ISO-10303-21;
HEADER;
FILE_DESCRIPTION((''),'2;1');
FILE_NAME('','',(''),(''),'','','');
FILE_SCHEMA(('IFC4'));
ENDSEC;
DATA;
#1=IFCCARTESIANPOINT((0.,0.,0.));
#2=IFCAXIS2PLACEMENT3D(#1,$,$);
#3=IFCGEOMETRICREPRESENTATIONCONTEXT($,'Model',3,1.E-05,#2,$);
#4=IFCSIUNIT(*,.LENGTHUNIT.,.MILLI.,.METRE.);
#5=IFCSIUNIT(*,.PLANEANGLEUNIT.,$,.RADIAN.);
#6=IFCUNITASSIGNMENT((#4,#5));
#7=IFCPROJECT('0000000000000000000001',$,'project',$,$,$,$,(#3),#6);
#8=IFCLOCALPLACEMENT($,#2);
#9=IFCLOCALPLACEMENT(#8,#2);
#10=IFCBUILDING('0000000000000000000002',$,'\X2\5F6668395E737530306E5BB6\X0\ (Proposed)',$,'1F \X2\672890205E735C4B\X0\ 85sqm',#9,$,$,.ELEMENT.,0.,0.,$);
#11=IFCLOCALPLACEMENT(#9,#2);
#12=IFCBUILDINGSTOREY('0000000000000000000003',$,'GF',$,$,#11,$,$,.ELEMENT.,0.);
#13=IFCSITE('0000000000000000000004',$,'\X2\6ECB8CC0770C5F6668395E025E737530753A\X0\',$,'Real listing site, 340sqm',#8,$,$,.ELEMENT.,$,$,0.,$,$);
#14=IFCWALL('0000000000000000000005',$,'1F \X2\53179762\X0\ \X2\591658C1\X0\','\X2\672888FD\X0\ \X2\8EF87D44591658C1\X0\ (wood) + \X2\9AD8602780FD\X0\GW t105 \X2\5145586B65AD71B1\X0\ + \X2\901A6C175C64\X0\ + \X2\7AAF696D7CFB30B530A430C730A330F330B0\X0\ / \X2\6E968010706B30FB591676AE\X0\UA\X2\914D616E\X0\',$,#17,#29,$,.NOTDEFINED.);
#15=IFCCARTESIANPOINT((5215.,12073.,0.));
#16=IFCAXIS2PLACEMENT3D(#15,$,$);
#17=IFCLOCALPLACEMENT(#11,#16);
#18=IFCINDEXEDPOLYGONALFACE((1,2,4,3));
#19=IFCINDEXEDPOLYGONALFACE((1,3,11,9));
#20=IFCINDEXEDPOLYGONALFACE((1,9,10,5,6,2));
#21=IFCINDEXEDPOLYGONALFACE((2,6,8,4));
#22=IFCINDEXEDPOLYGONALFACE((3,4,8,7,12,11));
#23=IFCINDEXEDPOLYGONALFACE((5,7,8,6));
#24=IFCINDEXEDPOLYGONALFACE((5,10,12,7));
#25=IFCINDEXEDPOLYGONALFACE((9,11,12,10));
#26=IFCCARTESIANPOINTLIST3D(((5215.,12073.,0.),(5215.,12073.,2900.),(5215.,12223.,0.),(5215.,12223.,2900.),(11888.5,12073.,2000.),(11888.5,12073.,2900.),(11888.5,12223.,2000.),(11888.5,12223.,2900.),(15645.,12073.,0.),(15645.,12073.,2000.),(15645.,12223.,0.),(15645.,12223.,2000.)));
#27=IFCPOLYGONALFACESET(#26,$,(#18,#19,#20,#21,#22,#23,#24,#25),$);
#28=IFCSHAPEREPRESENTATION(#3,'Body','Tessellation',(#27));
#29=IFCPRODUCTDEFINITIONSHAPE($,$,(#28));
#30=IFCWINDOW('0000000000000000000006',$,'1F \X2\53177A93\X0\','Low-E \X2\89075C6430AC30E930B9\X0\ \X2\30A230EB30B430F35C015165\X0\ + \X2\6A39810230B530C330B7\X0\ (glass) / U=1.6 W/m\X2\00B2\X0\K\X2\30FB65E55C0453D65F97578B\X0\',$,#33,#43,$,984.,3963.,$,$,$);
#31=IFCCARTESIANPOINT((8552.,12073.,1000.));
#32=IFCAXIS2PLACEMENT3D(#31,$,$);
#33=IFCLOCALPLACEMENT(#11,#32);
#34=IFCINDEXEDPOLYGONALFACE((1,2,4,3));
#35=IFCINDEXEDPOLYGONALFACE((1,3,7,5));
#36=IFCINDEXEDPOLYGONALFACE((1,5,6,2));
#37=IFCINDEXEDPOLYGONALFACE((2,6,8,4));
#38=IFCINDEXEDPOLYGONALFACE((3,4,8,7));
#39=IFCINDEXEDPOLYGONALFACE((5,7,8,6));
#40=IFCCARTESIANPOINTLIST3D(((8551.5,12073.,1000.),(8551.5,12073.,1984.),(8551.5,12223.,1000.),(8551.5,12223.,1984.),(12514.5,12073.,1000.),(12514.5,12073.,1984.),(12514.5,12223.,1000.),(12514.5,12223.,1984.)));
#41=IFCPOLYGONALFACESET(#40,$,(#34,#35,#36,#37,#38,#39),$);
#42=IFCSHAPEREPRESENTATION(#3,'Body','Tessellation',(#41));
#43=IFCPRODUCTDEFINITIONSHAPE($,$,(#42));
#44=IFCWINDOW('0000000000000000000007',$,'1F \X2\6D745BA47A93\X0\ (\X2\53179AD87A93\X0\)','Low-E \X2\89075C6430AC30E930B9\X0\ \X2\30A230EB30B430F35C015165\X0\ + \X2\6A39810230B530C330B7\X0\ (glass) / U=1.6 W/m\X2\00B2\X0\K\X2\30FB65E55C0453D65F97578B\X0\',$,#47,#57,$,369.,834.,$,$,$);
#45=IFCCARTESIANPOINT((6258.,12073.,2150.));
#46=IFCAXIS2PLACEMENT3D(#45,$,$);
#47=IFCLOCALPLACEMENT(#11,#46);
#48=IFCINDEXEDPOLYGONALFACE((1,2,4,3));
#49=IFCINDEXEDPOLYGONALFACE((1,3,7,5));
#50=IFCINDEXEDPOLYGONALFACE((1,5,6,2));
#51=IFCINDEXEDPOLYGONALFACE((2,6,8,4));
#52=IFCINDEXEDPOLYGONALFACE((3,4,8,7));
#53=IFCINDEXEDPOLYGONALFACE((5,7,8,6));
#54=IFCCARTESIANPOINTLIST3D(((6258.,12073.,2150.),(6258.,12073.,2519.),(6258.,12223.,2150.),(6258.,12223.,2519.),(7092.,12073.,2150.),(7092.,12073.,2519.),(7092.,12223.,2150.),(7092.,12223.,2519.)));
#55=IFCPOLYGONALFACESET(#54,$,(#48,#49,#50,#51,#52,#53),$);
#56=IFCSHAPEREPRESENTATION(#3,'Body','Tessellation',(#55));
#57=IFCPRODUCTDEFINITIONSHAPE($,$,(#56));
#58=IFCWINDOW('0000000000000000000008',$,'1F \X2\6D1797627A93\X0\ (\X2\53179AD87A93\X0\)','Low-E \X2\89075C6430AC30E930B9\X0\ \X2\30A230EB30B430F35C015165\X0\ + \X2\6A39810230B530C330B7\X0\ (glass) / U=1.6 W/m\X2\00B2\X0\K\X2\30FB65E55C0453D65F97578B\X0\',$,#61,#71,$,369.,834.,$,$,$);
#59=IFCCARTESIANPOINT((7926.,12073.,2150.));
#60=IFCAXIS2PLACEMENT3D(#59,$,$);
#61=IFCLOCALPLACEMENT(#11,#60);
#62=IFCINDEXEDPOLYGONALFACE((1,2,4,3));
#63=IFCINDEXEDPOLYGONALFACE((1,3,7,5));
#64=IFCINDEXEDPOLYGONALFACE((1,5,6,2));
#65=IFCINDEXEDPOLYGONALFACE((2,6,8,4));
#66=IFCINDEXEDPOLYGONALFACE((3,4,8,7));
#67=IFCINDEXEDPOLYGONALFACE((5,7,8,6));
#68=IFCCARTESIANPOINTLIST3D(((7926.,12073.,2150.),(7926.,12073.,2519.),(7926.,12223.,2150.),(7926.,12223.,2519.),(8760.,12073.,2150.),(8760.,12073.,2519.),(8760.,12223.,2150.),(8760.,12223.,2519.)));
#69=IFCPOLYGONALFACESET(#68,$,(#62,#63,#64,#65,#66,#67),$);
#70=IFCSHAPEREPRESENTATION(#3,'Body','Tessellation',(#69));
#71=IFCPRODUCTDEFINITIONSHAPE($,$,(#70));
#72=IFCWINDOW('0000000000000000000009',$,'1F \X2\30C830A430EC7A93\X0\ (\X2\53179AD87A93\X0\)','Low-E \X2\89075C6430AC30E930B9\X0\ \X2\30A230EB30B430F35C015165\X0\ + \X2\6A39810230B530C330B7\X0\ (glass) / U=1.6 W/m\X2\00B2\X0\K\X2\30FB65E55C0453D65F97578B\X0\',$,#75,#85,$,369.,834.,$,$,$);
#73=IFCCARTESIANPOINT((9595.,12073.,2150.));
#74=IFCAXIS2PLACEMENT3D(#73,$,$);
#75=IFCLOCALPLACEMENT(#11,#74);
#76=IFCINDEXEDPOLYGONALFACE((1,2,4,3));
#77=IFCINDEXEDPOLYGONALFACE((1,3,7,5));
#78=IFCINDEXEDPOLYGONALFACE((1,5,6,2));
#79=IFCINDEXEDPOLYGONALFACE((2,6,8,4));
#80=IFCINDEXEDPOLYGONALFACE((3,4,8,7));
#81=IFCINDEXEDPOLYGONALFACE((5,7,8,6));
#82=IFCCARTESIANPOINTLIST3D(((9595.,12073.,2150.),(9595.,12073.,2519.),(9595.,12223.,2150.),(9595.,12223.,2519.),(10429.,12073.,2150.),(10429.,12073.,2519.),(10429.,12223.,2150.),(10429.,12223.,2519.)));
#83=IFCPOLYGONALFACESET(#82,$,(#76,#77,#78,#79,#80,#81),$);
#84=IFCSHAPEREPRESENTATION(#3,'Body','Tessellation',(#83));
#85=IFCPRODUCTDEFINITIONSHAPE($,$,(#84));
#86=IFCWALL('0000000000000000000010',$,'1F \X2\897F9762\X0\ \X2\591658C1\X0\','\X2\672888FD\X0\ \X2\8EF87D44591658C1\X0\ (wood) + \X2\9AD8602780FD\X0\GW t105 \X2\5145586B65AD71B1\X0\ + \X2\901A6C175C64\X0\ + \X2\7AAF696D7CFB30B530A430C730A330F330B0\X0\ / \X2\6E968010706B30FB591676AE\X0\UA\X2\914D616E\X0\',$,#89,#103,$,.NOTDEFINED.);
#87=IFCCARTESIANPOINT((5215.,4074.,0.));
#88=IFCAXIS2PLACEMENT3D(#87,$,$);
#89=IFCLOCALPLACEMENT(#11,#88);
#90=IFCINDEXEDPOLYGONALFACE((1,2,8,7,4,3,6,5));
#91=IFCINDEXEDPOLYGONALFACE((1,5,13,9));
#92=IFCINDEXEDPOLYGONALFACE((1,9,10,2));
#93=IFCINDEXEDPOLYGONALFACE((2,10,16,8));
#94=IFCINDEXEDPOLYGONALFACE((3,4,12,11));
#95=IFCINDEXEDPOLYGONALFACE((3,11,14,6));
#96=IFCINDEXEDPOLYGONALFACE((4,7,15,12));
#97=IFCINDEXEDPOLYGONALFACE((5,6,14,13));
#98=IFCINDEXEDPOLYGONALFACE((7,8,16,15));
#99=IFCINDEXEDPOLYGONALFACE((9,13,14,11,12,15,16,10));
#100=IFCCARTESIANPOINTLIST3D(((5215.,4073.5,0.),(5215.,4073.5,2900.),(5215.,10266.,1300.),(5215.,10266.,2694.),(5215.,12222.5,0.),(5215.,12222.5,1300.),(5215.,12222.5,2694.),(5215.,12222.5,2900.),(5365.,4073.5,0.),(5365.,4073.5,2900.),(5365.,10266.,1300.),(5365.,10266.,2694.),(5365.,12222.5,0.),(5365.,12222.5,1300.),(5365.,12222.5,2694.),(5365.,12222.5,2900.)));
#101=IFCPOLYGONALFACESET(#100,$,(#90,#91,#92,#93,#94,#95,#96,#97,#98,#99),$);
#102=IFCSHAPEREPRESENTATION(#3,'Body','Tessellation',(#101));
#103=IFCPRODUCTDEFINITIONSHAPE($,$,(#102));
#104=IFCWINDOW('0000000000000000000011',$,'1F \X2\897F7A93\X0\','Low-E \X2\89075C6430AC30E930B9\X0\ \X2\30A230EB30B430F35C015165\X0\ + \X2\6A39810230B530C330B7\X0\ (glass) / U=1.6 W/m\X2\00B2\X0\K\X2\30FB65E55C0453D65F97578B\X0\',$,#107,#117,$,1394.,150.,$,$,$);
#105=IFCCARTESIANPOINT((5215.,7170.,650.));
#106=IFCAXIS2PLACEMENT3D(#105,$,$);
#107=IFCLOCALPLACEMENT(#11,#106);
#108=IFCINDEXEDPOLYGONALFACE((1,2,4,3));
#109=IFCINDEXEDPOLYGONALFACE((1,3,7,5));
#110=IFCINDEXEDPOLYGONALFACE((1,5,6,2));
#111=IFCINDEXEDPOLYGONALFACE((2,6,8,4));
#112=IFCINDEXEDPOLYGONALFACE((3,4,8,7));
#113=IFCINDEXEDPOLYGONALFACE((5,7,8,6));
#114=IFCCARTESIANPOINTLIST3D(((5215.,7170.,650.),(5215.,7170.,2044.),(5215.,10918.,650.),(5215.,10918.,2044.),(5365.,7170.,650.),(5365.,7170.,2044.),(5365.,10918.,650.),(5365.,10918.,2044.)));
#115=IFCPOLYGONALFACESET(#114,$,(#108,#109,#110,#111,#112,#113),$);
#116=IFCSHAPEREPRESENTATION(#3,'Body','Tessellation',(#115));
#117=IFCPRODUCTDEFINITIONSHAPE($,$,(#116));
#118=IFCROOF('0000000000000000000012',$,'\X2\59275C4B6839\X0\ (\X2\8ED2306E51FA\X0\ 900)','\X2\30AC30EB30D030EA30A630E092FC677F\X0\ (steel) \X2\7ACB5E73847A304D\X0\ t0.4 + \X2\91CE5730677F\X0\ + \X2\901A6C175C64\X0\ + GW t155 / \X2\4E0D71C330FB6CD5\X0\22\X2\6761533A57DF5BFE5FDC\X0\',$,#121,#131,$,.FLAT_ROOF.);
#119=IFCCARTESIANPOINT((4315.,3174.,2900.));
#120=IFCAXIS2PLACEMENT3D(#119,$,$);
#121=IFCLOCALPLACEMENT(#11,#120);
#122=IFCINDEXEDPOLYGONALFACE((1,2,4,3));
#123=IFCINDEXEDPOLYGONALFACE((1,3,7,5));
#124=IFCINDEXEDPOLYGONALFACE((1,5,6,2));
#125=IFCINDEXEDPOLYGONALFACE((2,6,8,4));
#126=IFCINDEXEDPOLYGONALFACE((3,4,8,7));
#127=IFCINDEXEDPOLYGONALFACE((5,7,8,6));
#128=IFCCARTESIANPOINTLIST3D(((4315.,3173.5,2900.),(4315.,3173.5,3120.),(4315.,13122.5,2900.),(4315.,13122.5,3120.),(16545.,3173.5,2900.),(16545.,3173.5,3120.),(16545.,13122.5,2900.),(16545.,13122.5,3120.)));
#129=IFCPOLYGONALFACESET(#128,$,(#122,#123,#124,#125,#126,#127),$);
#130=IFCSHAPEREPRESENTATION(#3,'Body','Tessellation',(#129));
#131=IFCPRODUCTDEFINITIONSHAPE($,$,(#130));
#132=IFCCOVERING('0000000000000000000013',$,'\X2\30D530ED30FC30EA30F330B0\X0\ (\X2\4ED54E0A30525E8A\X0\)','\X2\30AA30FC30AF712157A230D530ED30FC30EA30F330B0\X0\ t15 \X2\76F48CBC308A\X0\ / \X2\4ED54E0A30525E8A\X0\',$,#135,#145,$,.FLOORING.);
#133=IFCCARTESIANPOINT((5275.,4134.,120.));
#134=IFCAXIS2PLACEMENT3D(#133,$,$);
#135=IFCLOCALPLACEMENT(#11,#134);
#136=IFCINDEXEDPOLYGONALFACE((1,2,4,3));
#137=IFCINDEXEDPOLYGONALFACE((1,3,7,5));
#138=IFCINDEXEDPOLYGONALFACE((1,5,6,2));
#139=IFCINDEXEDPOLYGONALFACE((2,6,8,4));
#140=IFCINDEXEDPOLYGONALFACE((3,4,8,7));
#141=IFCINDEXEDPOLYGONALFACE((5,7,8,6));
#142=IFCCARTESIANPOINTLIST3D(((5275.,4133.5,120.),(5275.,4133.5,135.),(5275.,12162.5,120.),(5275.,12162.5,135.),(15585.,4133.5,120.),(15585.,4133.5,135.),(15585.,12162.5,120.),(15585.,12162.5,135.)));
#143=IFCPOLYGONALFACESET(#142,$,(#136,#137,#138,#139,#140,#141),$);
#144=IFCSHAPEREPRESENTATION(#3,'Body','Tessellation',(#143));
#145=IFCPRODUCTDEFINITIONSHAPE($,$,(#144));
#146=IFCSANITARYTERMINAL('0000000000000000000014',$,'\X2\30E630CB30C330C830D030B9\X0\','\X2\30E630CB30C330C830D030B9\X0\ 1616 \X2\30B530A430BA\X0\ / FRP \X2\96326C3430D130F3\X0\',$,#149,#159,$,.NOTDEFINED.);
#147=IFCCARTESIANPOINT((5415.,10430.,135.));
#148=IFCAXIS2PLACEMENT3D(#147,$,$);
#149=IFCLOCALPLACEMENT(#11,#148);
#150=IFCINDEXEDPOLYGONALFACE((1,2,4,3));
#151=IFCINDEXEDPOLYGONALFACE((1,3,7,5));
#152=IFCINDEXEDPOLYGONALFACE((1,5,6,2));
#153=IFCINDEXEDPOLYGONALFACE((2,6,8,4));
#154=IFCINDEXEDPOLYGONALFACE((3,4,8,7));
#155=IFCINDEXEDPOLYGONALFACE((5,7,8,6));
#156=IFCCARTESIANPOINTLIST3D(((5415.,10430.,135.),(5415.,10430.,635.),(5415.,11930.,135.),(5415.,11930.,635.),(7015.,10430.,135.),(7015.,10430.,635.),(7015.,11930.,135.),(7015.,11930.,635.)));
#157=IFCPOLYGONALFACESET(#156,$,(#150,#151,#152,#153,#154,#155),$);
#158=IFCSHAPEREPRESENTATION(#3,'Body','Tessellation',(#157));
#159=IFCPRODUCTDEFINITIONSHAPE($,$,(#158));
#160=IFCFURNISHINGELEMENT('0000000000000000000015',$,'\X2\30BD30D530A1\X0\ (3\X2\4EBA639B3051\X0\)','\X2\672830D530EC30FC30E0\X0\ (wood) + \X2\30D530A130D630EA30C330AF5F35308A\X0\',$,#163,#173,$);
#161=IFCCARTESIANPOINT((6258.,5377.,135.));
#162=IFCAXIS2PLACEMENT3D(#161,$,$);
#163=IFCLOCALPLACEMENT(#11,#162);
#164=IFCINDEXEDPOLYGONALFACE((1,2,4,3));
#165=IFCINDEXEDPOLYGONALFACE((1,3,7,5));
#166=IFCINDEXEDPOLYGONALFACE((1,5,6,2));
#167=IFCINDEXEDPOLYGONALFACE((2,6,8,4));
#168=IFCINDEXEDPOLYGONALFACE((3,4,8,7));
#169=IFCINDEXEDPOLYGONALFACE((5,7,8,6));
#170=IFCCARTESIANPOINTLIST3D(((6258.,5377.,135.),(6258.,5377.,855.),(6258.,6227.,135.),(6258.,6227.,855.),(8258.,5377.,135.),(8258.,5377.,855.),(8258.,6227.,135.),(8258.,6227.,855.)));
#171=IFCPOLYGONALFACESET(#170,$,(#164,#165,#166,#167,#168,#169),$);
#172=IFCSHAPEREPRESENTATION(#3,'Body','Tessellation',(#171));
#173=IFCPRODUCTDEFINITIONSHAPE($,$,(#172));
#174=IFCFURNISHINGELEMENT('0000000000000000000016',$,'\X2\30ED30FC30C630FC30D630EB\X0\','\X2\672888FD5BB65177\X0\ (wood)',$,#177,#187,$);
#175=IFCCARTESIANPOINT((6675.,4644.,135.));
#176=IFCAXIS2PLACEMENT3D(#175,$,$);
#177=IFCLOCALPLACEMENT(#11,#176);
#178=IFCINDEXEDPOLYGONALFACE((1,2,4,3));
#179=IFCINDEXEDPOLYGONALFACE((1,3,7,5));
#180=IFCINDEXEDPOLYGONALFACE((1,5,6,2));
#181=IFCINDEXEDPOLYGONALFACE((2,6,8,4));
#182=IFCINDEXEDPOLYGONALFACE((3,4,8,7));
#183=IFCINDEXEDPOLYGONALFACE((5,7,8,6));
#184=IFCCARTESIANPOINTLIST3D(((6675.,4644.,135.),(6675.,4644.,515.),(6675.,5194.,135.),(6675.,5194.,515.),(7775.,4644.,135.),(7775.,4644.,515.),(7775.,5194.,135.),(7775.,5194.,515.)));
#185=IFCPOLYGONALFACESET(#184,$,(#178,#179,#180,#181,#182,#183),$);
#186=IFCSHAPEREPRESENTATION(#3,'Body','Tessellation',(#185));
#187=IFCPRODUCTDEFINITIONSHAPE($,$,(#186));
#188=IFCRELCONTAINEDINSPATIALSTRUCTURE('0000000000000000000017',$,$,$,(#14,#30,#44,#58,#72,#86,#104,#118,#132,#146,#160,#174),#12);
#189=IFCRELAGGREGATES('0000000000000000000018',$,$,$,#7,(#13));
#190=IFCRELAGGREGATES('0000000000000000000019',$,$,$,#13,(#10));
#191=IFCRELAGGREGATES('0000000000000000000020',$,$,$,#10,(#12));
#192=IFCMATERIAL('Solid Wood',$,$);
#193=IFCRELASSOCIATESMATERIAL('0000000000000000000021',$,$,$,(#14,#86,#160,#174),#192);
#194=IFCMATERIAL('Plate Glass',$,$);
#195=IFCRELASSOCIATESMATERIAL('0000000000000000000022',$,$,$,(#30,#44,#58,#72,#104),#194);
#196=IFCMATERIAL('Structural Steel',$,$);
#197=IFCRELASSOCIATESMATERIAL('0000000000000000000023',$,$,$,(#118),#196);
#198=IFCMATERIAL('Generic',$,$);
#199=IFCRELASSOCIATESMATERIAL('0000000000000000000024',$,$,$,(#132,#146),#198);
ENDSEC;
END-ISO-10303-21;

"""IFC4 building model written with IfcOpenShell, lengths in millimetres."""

from ifc_helpers import new_model, si_unit, frame, frame_2d, origin, place, context, project, spatial, rectangle, extrude, material, element, fill, save


model = new_model("IFC4")

# Units and contexts
model_context = context("Model", 3, precision=1e-05, world=origin())
ifc_project = project(units=[si_unit("LENGTHUNIT", "METRE", prefix="MILLI"), si_unit("PLANEANGLEUNIT", "RADIAN")], contexts=[model_context])

# Site, building, storey
site_placement = place(None, origin())
site = spatial("IfcSite", under=ifc_project, at=site_placement, Name="滋賀県彦根市平田町", ObjectType="Real listing site, 340sqm", CompositionType="ELEMENT", RefElevation=0.0)
building_placement = place(site_placement, origin())
building = spatial("IfcBuilding", under=site, at=building_placement, Name="彦根平田の家 (Proposed)", ObjectType="1F 木造平屋 85sqm", CompositionType="ELEMENT", ElevationOfRefHeight=0.0, ElevationOfTerrain=0.0)
storey_placement = place(building_placement, origin())
storey = spatial("IfcBuildingStorey", under=building, at=storey_placement, Name="GF", CompositionType="ELEMENT", Elevation=0.0)

# Shared definitions
ifc_material_1 = material(Name="Solid Wood")

# Shared definitions
ifc_material_2 = material(Name="Plate Glass")

# Wall, openings, windows
wall_1_placement = place(storey_placement, frame((5215.0, 12073.0, 0.0)))
wall_1 = element("IfcWall", 1, at=wall_1_placement, inside=storey, material=ifc_material_1, Name="1F 北面 外壁", Description="木製 軸組外壁 (wood) + 高性能GW t105 充填断熱 + 通気層 + 窯業系サイディング / 準耐火・外皮UA配慮", PredefinedType="NOTDEFINED", context=model_context, shape_type="SweptSolid", body=[
    extrude(rectangle(XDim=10430.0, YDim=150.0, at=frame_2d((5215.0, 75.0))), frame((5215.0, 12073.0, 0.0)), (0.0, 0.0, 1.0), 2900.0),
])
opening_1_placement = place(storey_placement, frame((8552.0, 12073.0, 1000.0)))
opening_1 = element("IfcOpeningElement", 2, at=opening_1_placement, cuts=wall_1, PredefinedType="NOTDEFINED", context=model_context, shape_type="SweptSolid", body=[
    extrude(rectangle(XDim=3963.0, YDim=150.0, at=frame_2d((1981.0, 75.0))), frame((8552.0, 12073.0, 1000.0)), (0.0, 0.0, 1.0), 984.0),
])
opening_2_placement = place(storey_placement, frame((6258.0, 12073.0, 2150.0)))
opening_2 = element("IfcOpeningElement", 3, at=opening_2_placement, cuts=wall_1, PredefinedType="NOTDEFINED", context=model_context, shape_type="SweptSolid", body=[
    extrude(rectangle(XDim=834.0, YDim=150.0, at=frame_2d((417.0, 75.0))), frame((6258.0, 12073.0, 2150.0)), (0.0, 0.0, 1.0), 369.0),
])
opening_3_placement = place(storey_placement, frame((7926.0, 12073.0, 2150.0)))
opening_3 = element("IfcOpeningElement", 4, at=opening_3_placement, cuts=wall_1, PredefinedType="NOTDEFINED", context=model_context, shape_type="SweptSolid", body=[
    extrude(rectangle(XDim=834.0, YDim=150.0, at=frame_2d((417.0, 75.0))), frame((7926.0, 12073.0, 2150.0)), (0.0, 0.0, 1.0), 369.0),
])
opening_4_placement = place(storey_placement, frame((9595.0, 12073.0, 2150.0)))
opening_4 = element("IfcOpeningElement", 5, at=opening_4_placement, cuts=wall_1, PredefinedType="NOTDEFINED", context=model_context, shape_type="SweptSolid", body=[
    extrude(rectangle(XDim=834.0, YDim=150.0, at=frame_2d((417.0, 75.0))), frame((9595.0, 12073.0, 2150.0)), (0.0, 0.0, 1.0), 369.0),
])
window_1_placement = place(storey_placement, frame((8552.0, 12073.0, 1000.0)))
window_1 = element("IfcWindow", 6, at=window_1_placement, inside=storey, material=ifc_material_2, Name="1F 北窓", Description="Low-E 複層ガラス アルゴン封入 + 樹脂サッシ (glass) / U=1.6 W/m²K・日射取得型", OverallHeight=984.0, OverallWidth=3963.0, context=model_context, shape_type="SweptSolid", body=[
    extrude(rectangle(XDim=3963.0, YDim=150.0, at=frame_2d((1981.0, 75.0))), frame((8552.0, 12073.0, 1000.0)), (0.0, 0.0, 1.0), 984.0),
])
fill(opening_1, window_1)
window_2_placement = place(storey_placement, frame((6258.0, 12073.0, 2150.0)))
window_2 = element("IfcWindow", 7, at=window_2_placement, inside=storey, material=ifc_material_2, Name="1F 浴室窓 (北高窓)", Description="Low-E 複層ガラス アルゴン封入 + 樹脂サッシ (glass) / U=1.6 W/m²K・日射取得型", OverallHeight=369.0, OverallWidth=834.0, context=model_context, shape_type="SweptSolid", body=[
    extrude(rectangle(XDim=834.0, YDim=150.0, at=frame_2d((417.0, 75.0))), frame((6258.0, 12073.0, 2150.0)), (0.0, 0.0, 1.0), 369.0),
])
fill(opening_2, window_2)
window_3_placement = place(storey_placement, frame((7926.0, 12073.0, 2150.0)))
window_3 = element("IfcWindow", 8, at=window_3_placement, inside=storey, material=ifc_material_2, Name="1F 洗面窓 (北高窓)", Description="Low-E 複層ガラス アルゴン封入 + 樹脂サッシ (glass) / U=1.6 W/m²K・日射取得型", OverallHeight=369.0, OverallWidth=834.0, context=model_context, shape_type="SweptSolid", body=[
    extrude(rectangle(XDim=834.0, YDim=150.0, at=frame_2d((417.0, 75.0))), frame((7926.0, 12073.0, 2150.0)), (0.0, 0.0, 1.0), 369.0),
])
fill(opening_3, window_3)
window_4_placement = place(storey_placement, frame((9595.0, 12073.0, 2150.0)))
window_4 = element("IfcWindow", 9, at=window_4_placement, inside=storey, material=ifc_material_2, Name="1F トイレ窓 (北高窓)", Description="Low-E 複層ガラス アルゴン封入 + 樹脂サッシ (glass) / U=1.6 W/m²K・日射取得型", OverallHeight=369.0, OverallWidth=834.0, context=model_context, shape_type="SweptSolid", body=[
    extrude(rectangle(XDim=834.0, YDim=150.0, at=frame_2d((417.0, 75.0))), frame((9595.0, 12073.0, 2150.0)), (0.0, 0.0, 1.0), 369.0),
])
fill(opening_4, window_4)

# Wall, opening, window
wall_2_placement = place(storey_placement, frame((5215.0, 4074.0, 0.0)))
wall_2 = element("IfcWall", 10, at=wall_2_placement, inside=storey, material=ifc_material_1, Name="1F 西面 外壁", Description="木製 軸組外壁 (wood) + 高性能GW t105 充填断熱 + 通気層 + 窯業系サイディング / 準耐火・外皮UA配慮", PredefinedType="NOTDEFINED", context=model_context, shape_type="SweptSolid", body=[
    extrude(rectangle(XDim=150.0, YDim=8149.0, at=frame_2d((75.0, 4074.0))), frame((5215.0, 4074.0, 0.0)), (0.0, 0.0, 1.0), 2900.0),
])
opening_5_placement = place(storey_placement, frame((5215.0, 7170.0, 650.0)))
opening_5 = element("IfcOpeningElement", 11, at=opening_5_placement, cuts=wall_2, PredefinedType="NOTDEFINED", context=model_context, shape_type="SweptSolid", body=[
    extrude(rectangle(XDim=150.0, YDim=3748.0, at=frame_2d((75.0, 1874.0))), frame((5215.0, 7170.0, 650.0)), (0.0, 0.0, 1.0), 1394.0),
])
window_5_placement = place(storey_placement, frame((5215.0, 7170.0, 650.0)))
window_5 = element("IfcWindow", 12, at=window_5_placement, inside=storey, material=ifc_material_2, Name="1F 西窓", Description="Low-E 複層ガラス アルゴン封入 + 樹脂サッシ (glass) / U=1.6 W/m²K・日射取得型", OverallHeight=1394.0, OverallWidth=150.0, context=model_context, shape_type="SweptSolid", body=[
    extrude(rectangle(XDim=150.0, YDim=3748.0, at=frame_2d((75.0, 1874.0))), frame((5215.0, 7170.0, 650.0)), (0.0, 0.0, 1.0), 1394.0),
])
fill(opening_5, window_5)

# Roof
ifc_material_3 = material(Name="Structural Steel")
roof_placement = place(storey_placement, frame((4315.0, 3174.0, 2900.0)))
element("IfcRoof", 13, at=roof_placement, inside=storey, material=ifc_material_3, Name="大屋根 (軒の出 900)", Description="ガルバリウム鋼板 (steel) 立平葺き t0.4 + 野地板 + 通気層 + GW t155 / 不燃・法22条区域対応", PredefinedType="FLAT_ROOF", context=model_context, shape_type="SweptSolid", body=[
    extrude(rectangle(XDim=12230.0, YDim=9949.0, at=frame_2d((6115.0, 4974.0))), frame((4315.0, 3174.0, 2900.0)), (0.0, 0.0, 1.0), 220.0),
])

# Covering
ifc_material_4 = material(Name="Generic")
covering_placement = place(storey_placement, frame((5275.0, 4134.0, 120.0)))
element("IfcCovering", 14, at=covering_placement, inside=storey, material=ifc_material_4, Name="フローリング (仕上げ床)", Description="オーク無垢フローリング t15 直貼り / 仕上げ床", PredefinedType="FLOORING", context=model_context, shape_type="SweptSolid", body=[
    extrude(rectangle(XDim=10310.0, YDim=8029.0, at=frame_2d((5155.0, 4014.0))), frame((5275.0, 4134.0, 120.0)), (0.0, 0.0, 1.0), 15.0),
])

# Sanitary terminal
sanitary_terminal_placement = place(storey_placement, frame((5415.0, 10430.0, 135.0)))
element("IfcSanitaryTerminal", 15, at=sanitary_terminal_placement, inside=storey, material=ifc_material_4, Name="ユニットバス", Description="ユニットバス 1616 サイズ / FRP 防水パン", PredefinedType="NOTDEFINED", context=model_context, shape_type="SweptSolid", body=[
    extrude(rectangle(XDim=1600.0, YDim=1500.0, at=frame_2d((800.0, 750.0))), frame((5415.0, 10430.0, 135.0)), (0.0, 0.0, 1.0), 500.0),
])

# Furnishing elements
furnishing_1_placement = place(storey_placement, frame((6258.0, 5377.0, 135.0)))
element("IfcFurnishingElement", 16, at=furnishing_1_placement, inside=storey, material=ifc_material_1, Name="ソファ (3人掛け)", Description="木フレーム (wood) + ファブリック張り", context=model_context, shape_type="SweptSolid", body=[
    extrude(rectangle(XDim=2000.0, YDim=850.0, at=frame_2d((1000.0, 425.0))), frame((6258.0, 5377.0, 135.0)), (0.0, 0.0, 1.0), 720.0),
])
furnishing_2_placement = place(storey_placement, frame((6675.0, 4644.0, 135.0)))
element("IfcFurnishingElement", 17, at=furnishing_2_placement, inside=storey, material=ifc_material_1, Name="ローテーブル", Description="木製家具 (wood)", context=model_context, shape_type="SweptSolid", body=[
    extrude(rectangle(XDim=1100.0, YDim=550.0, at=frame_2d((550.0, 275.0))), frame((6675.0, 4644.0, 135.0)), (0.0, 0.0, 1.0), 380.0),
])

save(model, "model.ifc")
